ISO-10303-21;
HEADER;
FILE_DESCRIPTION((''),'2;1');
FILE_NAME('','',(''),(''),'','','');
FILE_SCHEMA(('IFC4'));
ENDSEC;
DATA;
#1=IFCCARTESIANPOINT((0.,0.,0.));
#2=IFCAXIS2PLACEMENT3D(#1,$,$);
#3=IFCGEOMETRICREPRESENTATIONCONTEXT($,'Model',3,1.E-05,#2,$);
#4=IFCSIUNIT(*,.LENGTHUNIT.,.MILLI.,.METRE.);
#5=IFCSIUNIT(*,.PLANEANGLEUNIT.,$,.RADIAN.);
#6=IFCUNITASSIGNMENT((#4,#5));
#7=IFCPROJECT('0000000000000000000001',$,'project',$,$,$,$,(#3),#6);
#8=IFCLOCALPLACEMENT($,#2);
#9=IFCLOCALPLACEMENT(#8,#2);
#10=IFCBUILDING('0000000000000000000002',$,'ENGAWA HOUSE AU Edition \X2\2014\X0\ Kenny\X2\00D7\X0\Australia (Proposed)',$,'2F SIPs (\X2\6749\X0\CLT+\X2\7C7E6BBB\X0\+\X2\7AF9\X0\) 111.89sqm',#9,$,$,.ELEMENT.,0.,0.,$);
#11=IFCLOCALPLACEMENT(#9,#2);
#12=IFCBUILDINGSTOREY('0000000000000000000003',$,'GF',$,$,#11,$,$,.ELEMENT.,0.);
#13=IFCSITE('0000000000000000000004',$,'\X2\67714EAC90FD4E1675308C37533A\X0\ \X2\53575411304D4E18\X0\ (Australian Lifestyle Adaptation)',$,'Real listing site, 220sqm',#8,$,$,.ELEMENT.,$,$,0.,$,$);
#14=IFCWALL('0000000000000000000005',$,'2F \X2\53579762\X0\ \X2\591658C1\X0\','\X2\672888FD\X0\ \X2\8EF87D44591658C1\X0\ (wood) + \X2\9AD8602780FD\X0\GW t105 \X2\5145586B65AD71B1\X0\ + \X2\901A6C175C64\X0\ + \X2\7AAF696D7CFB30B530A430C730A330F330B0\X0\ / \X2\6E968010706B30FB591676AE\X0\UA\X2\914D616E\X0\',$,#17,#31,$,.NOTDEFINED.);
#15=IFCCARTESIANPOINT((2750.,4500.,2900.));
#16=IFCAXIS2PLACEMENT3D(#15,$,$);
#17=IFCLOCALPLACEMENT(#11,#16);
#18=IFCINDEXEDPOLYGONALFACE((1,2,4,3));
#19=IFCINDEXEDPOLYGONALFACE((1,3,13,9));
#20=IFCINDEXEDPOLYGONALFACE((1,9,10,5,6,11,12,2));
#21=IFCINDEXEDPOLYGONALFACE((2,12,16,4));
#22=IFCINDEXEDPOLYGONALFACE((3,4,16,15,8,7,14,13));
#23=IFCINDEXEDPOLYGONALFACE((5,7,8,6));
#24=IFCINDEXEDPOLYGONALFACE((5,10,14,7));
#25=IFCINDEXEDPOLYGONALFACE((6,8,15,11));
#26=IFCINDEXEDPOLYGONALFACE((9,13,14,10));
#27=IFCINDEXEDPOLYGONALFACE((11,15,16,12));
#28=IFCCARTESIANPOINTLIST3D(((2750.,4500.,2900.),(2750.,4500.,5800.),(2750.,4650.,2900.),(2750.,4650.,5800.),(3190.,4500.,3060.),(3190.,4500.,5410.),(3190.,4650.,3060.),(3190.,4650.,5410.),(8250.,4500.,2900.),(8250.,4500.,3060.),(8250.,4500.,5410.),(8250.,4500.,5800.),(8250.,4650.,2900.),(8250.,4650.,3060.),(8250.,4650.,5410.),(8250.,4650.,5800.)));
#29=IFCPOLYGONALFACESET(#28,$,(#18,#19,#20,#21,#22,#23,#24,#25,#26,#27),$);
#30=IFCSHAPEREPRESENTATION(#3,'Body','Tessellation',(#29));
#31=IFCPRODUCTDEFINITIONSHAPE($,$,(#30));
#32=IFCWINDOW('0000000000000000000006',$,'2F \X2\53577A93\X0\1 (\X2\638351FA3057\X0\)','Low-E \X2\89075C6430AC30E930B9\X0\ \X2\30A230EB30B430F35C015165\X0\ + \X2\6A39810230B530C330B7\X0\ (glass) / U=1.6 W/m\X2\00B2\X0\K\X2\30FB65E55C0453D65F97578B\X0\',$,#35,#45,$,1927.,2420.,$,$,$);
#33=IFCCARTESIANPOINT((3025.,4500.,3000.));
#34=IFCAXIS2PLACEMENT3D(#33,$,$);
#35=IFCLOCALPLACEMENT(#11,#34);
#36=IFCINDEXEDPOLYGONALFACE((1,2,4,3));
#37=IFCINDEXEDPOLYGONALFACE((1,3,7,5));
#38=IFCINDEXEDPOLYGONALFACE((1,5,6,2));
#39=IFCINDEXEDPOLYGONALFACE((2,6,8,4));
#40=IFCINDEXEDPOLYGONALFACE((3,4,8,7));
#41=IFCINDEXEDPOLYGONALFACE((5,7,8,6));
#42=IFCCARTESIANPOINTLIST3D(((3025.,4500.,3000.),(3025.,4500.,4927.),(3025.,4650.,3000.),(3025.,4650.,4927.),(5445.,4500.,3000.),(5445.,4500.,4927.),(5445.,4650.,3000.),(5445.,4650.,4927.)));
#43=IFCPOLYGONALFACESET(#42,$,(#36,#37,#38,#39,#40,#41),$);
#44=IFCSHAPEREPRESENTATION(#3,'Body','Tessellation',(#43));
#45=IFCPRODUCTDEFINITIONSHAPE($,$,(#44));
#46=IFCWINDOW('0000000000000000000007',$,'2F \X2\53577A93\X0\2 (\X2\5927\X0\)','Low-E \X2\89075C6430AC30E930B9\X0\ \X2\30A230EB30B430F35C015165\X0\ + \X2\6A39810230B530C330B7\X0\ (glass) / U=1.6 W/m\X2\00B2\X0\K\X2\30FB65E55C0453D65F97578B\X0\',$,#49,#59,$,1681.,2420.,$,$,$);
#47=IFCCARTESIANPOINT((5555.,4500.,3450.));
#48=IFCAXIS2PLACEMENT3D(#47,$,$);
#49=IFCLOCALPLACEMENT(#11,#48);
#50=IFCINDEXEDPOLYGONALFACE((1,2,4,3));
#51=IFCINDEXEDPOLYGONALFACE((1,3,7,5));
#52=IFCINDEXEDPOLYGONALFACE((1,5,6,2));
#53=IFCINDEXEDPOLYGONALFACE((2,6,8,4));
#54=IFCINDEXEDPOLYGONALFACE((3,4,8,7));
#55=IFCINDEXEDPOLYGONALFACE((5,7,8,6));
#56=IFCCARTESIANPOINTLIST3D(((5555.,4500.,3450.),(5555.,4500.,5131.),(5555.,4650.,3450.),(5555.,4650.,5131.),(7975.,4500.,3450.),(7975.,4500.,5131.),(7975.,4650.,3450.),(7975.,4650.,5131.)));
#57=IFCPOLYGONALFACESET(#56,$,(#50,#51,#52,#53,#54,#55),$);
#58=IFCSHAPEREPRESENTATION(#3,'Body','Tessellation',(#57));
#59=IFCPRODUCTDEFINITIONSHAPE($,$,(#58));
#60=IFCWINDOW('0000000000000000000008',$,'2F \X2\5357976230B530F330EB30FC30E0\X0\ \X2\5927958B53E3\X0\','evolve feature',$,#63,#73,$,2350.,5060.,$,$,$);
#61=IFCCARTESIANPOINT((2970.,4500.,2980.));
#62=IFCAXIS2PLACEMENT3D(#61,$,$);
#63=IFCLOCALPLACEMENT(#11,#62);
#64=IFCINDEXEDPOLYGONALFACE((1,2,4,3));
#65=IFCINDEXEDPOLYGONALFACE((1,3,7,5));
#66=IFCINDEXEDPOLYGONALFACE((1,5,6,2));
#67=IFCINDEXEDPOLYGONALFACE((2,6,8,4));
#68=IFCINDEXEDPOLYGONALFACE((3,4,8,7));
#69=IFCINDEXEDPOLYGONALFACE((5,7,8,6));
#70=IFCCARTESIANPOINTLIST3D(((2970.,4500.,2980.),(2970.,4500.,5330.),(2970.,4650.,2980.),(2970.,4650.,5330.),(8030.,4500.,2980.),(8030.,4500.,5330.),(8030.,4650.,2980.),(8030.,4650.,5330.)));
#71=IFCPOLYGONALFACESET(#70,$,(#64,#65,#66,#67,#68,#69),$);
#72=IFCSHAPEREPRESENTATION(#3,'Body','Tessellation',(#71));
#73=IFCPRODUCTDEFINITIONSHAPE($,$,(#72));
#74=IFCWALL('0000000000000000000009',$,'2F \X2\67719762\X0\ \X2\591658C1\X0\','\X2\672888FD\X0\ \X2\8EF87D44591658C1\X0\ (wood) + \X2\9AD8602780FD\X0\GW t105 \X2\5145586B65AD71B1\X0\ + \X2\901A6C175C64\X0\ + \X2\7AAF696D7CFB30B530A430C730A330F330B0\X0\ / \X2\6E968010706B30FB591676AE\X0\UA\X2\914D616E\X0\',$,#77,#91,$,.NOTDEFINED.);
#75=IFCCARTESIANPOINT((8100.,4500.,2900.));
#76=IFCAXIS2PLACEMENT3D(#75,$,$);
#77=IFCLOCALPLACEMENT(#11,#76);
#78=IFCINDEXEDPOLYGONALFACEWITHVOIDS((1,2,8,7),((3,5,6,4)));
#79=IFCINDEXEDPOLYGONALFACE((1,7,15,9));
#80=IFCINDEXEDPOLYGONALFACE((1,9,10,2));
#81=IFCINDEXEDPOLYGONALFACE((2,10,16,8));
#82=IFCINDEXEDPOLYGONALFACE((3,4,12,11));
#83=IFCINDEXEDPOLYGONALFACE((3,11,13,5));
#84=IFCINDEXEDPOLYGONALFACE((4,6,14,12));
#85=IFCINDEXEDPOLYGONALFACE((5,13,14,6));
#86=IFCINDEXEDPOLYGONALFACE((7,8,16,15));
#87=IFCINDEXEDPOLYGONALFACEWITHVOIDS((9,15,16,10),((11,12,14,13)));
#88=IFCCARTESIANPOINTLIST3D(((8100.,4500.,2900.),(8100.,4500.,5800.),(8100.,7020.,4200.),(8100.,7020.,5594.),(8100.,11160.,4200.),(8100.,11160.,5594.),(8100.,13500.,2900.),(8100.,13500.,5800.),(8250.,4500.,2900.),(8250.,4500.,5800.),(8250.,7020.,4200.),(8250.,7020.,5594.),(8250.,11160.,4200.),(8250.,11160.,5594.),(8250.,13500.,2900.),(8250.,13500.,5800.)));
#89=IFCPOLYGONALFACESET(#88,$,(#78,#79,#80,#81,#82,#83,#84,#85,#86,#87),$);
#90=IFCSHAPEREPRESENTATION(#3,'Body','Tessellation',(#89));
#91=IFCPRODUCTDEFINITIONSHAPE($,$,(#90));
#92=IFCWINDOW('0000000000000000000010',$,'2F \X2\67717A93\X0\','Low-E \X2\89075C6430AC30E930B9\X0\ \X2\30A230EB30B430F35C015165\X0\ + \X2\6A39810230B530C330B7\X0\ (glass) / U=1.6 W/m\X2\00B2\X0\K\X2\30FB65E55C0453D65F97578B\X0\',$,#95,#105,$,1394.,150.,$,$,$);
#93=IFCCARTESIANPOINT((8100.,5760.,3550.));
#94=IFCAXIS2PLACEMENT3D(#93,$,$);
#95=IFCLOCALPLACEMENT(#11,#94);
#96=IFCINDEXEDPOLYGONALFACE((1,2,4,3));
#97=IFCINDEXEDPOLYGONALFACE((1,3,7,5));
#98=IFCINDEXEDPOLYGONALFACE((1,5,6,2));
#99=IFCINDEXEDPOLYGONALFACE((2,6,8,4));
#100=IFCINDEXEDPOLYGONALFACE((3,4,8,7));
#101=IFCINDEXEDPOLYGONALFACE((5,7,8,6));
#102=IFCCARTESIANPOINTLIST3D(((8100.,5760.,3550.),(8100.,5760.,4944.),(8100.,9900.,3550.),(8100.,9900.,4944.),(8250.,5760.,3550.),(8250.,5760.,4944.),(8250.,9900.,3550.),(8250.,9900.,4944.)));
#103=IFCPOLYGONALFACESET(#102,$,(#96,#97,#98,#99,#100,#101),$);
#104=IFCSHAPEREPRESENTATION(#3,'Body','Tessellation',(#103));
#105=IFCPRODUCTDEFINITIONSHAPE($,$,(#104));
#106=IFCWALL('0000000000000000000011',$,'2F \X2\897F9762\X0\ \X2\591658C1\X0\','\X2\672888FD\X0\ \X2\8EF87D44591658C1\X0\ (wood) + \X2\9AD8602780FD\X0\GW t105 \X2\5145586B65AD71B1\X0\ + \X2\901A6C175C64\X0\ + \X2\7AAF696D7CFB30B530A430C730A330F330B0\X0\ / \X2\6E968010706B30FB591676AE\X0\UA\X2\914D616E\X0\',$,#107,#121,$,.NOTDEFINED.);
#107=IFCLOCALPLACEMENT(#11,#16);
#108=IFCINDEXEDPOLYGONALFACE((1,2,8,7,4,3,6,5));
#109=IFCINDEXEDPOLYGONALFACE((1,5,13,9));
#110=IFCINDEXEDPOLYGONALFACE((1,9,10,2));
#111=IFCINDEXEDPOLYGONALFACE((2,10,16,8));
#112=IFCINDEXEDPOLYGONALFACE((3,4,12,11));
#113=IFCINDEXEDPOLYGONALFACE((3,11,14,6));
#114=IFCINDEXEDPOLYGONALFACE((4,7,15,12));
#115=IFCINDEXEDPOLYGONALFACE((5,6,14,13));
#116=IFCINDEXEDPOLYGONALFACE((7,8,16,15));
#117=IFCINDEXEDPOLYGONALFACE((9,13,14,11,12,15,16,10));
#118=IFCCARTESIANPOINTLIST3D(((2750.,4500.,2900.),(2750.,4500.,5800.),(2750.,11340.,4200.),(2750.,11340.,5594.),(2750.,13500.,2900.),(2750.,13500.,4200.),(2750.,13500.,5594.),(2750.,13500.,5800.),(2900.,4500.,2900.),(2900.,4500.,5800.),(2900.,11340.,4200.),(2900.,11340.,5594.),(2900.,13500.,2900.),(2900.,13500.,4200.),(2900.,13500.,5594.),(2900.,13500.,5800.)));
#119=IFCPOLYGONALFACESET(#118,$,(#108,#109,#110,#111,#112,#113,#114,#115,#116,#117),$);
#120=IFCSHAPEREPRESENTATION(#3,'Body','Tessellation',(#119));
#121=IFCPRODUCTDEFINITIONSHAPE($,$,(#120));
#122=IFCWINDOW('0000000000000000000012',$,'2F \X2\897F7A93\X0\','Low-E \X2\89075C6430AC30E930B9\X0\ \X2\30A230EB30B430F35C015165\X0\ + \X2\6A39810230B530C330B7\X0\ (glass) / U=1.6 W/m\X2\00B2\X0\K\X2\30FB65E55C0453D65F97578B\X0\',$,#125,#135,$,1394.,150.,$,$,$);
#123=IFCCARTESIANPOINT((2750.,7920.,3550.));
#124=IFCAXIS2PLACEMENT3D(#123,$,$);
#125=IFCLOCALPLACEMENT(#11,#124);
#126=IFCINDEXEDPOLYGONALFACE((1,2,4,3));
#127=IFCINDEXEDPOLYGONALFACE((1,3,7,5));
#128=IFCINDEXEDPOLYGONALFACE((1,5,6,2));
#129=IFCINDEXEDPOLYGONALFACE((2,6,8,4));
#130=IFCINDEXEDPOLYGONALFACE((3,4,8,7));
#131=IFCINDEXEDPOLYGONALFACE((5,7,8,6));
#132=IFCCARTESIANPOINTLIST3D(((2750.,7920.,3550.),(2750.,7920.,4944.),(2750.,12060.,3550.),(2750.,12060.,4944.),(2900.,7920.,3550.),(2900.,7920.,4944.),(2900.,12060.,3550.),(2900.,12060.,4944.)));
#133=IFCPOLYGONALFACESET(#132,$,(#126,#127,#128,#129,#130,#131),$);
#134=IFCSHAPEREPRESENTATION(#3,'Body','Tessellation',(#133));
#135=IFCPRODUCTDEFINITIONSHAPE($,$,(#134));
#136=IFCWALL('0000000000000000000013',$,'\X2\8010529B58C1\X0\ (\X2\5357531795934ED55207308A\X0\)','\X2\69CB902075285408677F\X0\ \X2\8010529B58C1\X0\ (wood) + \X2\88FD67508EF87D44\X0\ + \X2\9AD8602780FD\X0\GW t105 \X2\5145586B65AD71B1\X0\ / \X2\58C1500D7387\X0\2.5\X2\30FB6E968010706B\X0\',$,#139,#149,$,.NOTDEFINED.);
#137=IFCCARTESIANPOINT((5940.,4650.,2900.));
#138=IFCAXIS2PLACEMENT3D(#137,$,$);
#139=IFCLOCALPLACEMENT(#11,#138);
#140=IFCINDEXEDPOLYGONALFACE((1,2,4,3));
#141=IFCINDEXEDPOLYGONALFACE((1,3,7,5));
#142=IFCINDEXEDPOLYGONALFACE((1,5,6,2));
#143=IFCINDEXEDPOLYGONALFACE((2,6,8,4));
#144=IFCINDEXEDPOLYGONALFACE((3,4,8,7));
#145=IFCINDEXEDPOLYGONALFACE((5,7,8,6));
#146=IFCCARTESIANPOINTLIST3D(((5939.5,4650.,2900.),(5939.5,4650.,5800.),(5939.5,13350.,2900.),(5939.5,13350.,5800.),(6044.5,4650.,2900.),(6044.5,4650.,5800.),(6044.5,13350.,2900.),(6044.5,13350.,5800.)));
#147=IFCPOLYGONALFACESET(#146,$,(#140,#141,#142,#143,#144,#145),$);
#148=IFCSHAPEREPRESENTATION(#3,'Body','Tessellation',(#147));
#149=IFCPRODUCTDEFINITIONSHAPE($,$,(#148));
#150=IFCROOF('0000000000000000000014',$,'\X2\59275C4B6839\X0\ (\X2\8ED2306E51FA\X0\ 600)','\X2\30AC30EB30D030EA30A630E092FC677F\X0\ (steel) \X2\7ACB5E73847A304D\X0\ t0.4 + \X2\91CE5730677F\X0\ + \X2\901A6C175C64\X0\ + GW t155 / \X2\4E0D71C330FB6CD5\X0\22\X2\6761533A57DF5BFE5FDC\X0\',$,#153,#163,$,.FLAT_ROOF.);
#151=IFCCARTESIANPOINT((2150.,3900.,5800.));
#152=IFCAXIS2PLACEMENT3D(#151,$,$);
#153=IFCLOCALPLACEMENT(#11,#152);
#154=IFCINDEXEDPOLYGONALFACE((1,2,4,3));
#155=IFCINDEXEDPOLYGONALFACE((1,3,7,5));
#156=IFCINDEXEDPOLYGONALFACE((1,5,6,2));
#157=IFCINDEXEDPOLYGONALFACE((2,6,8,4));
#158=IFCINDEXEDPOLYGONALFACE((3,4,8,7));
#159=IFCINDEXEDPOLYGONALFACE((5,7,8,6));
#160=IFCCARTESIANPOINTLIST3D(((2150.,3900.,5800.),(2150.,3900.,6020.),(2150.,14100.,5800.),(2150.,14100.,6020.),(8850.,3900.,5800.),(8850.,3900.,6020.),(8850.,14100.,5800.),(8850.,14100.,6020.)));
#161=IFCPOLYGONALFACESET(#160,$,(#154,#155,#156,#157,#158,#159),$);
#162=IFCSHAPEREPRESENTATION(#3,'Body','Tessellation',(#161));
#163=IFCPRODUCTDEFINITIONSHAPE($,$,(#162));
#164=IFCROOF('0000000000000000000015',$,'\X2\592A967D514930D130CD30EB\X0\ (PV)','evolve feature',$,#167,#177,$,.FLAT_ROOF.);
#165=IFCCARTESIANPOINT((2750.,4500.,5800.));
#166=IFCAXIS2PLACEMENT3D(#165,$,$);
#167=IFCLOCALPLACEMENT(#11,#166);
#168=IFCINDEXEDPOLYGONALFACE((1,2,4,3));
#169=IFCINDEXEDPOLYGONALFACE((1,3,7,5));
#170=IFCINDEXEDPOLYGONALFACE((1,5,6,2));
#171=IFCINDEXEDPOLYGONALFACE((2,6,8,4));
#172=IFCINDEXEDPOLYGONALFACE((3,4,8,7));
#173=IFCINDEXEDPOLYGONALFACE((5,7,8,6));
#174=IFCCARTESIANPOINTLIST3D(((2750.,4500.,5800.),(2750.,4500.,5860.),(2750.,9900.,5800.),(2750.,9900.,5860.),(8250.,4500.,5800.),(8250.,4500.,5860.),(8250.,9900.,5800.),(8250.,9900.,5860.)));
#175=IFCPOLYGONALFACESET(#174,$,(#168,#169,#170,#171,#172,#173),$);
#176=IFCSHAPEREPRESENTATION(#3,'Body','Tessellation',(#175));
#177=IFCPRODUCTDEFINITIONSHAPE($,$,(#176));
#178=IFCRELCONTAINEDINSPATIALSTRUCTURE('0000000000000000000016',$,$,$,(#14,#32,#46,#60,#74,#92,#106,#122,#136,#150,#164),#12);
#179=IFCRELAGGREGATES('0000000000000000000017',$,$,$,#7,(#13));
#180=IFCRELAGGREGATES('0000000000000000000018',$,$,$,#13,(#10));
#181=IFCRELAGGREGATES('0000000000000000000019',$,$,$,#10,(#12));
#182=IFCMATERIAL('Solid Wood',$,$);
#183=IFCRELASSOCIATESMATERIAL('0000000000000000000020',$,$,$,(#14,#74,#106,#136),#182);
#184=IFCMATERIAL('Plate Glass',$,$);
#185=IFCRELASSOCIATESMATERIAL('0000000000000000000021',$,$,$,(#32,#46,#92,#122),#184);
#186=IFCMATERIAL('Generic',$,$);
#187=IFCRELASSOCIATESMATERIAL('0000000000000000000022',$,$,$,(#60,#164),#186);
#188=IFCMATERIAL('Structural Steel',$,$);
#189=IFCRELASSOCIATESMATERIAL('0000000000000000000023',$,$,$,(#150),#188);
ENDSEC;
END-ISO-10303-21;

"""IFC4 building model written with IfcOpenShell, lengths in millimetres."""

from ifc_helpers import new_model, si_unit, frame, frame_2d, origin, place, context, project, spatial, rectangle, extrude, material, element, fill, save


model = new_model("IFC4")

# Units and contexts
model_context = context("Model", 3, precision=1e-05, world=origin())
ifc_project = project(units=[si_unit("LENGTHUNIT", "METRE", prefix="MILLI"), si_unit("PLANEANGLEUNIT", "RADIAN")], contexts=[model_context])

# Site, building, storey
site_placement = place(None, origin())
site = spatial("IfcSite", under=ifc_project, at=site_placement, Name="東京都世田谷区 南向き丘 (Australian Lifestyle Adaptation)", ObjectType="Real listing site, 220sqm", CompositionType="ELEMENT", RefElevation=0.0)
building_placement = place(site_placement, origin())
building = spatial("IfcBuilding", under=site, at=building_placement, Name="ENGAWA HOUSE AU Edition — Kenny×Australia (Proposed)", ObjectType="2F SIPs (杉CLT+籾殻+竹) 111.89sqm", CompositionType="ELEMENT", ElevationOfRefHeight=0.0, ElevationOfTerrain=0.0)
storey_placement = place(building_placement, origin())
storey = spatial("IfcBuildingStorey", under=building, at=storey_placement, Name="GF", CompositionType="ELEMENT", Elevation=0.0)

# Shared definitions
ifc_material_1 = material(Name="Solid Wood")

# Wall, openings, windows
wall_1_placement = place(storey_placement, frame((2750.0, 4500.0, 2900.0)))
wall_1 = element("IfcWall", 1, at=wall_1_placement, inside=storey, material=ifc_material_1, Name="2F 南面 外壁", Description="木製 軸組外壁 (wood) + 高性能GW t105 充填断熱 + 通気層 + 窯業系サイディング / 準耐火・外皮UA配慮", PredefinedType="NOTDEFINED", context=model_context, shape_type="SweptSolid", body=[
    extrude(rectangle(XDim=5500.0, YDim=150.0, at=frame_2d((2750.0, 75.0))), frame((2750.0, 4500.0, 2900.0)), (0.0, 0.0, 1.0), 2900.0),
])
opening_1_placement = place(storey_placement, frame((3025.0, 4500.0, 3000.0)))
opening_1 = element("IfcOpeningElement", 2, at=opening_1_placement, cuts=wall_1, PredefinedType="NOTDEFINED", context=model_context, shape_type="SweptSolid", body=[
    extrude(rectangle(XDim=2420.0, YDim=150.0, at=frame_2d((1210.0, 75.0))), frame((3025.0, 4500.0, 3000.0)), (0.0, 0.0, 1.0), 1927.0),
])
opening_2_placement = place(storey_placement, frame((5555.0, 4500.0, 3450.0)))
opening_2 = element("IfcOpeningElement", 3, at=opening_2_placement, cuts=wall_1, PredefinedType="NOTDEFINED", context=model_context, shape_type="SweptSolid", body=[
    extrude(rectangle(XDim=2420.0, YDim=150.0, at=frame_2d((1210.0, 75.0))), frame((5555.0, 4500.0, 3450.0)), (0.0, 0.0, 1.0), 1681.0),
])
opening_3_placement = place(storey_placement, frame((2970.0, 4500.0, 2980.0)))
opening_3 = element("IfcOpeningElement", 4, at=opening_3_placement, cuts=wall_1, PredefinedType="NOTDEFINED", context=model_context, shape_type="SweptSolid", body=[
    extrude(rectangle(XDim=5060.0, YDim=150.0, at=frame_2d((2530.0, 75.0))), frame((2970.0, 4500.0, 2980.0)), (0.0, 0.0, 1.0), 2350.0),
])
ifc_material_2 = material(Name="Plate Glass")
window_1_placement = place(storey_placement, frame((3025.0, 4500.0, 3000.0)))
window_1 = element("IfcWindow", 5, at=window_1_placement, inside=storey, material=ifc_material_2, Name="2F 南窓1 (掃出し)", Description="Low-E 複層ガラス アルゴン封入 + 樹脂サッシ (glass) / U=1.6 W/m²K・日射取得型", OverallHeight=1927.0, OverallWidth=2420.0, context=model_context, shape_type="SweptSolid", body=[
    extrude(rectangle(XDim=2420.0, YDim=150.0, at=frame_2d((1210.0, 75.0))), frame((3025.0, 4500.0, 3000.0)), (0.0, 0.0, 1.0), 1927.0),
])
fill(opening_1, window_1)
window_2_placement = place(storey_placement, frame((5555.0, 4500.0, 3450.0)))
window_2 = element("IfcWindow", 6, at=window_2_placement, inside=storey, material=ifc_material_2, Name="2F 南窓2 (大)", Description="Low-E 複層ガラス アルゴン封入 + 樹脂サッシ (glass) / U=1.6 W/m²K・日射取得型", OverallHeight=1681.0, OverallWidth=2420.0, context=model_context, shape_type="SweptSolid", body=[
    extrude(rectangle(XDim=2420.0, YDim=150.0, at=frame_2d((1210.0, 75.0))), frame((5555.0, 4500.0, 3450.0)), (0.0, 0.0, 1.0), 1681.0),
])
fill(opening_2, window_2)
ifc_material_3 = material(Name="Generic")
window_3_placement = place(storey_placement, frame((2970.0, 4500.0, 2980.0)))
window_3 = element("IfcWindow", 7, at=window_3_placement, inside=storey, material=ifc_material_3, Name="2F 南面サンルーム 大開口", Description="evolve feature", OverallHeight=2350.0, OverallWidth=5060.0, context=model_context, shape_type="SweptSolid", body=[
    extrude(rectangle(XDim=5060.0, YDim=150.0, at=frame_2d((2530.0, 75.0))), frame((2970.0, 4500.0, 2980.0)), (0.0, 0.0, 1.0), 2350.0),
])
fill(opening_3, window_3)

# Walls, openings, windows
wall_2_placement = place(storey_placement, frame((8100.0, 4500.0, 2900.0)))
wall_2 = element("IfcWall", 8, at=wall_2_placement, inside=storey, material=ifc_material_1, Name="2F 東面 外壁", Description="木製 軸組外壁 (wood) + 高性能GW t105 充填断熱 + 通気層 + 窯業系サイディング / 準耐火・外皮UA配慮", PredefinedType="NOTDEFINED", context=model_context, shape_type="SweptSolid", body=[
    extrude(rectangle(XDim=150.0, YDim=9000.0, at=frame_2d((75.0, 4500.0))), frame((8100.0, 4500.0, 2900.0)), (0.0, 0.0, 1.0), 2900.0),
])
opening_4_placement = place(storey_placement, frame((8100.0, 5760.0, 3550.0)))
opening_4 = element("IfcOpeningElement", 9, at=opening_4_placement, cuts=wall_2, PredefinedType="NOTDEFINED", context=model_context, shape_type="SweptSolid", body=[
    extrude(rectangle(XDim=150.0, YDim=4140.0, at=frame_2d((75.0, 2070.0))), frame((8100.0, 5760.0, 3550.0)), (0.0, 0.0, 1.0), 1394.0),
])
window_4_placement = place(storey_placement, frame((8100.0, 5760.0, 3550.0)))
window_4 = element("IfcWindow", 10, at=window_4_placement, inside=storey, material=ifc_material_2, Name="2F 東窓", Description="Low-E 複層ガラス アルゴン封入 + 樹脂サッシ (glass) / U=1.6 W/m²K・日射取得型", OverallHeight=1394.0, OverallWidth=150.0, context=model_context, shape_type="SweptSolid", body=[
    extrude(rectangle(XDim=150.0, YDim=4140.0, at=frame_2d((75.0, 2070.0))), frame((8100.0, 5760.0, 3550.0)), (0.0, 0.0, 1.0), 1394.0),
])
fill(opening_4, window_4)
wall_3_placement = place(storey_placement, frame((2750.0, 4500.0, 2900.0)))
wall_3 = element("IfcWall", 11, at=wall_3_placement, inside=storey, material=ifc_material_1, Name="2F 西面 外壁", Description="木製 軸組外壁 (wood) + 高性能GW t105 充填断熱 + 通気層 + 窯業系サイディング / 準耐火・外皮UA配慮", PredefinedType="NOTDEFINED", context=model_context, shape_type="SweptSolid", body=[
    extrude(rectangle(XDim=150.0, YDim=9000.0, at=frame_2d((75.0, 4500.0))), frame((2750.0, 4500.0, 2900.0)), (0.0, 0.0, 1.0), 2900.0),
])
opening_5_placement = place(storey_placement, frame((2750.0, 7920.0, 3550.0)))
opening_5 = element("IfcOpeningElement", 12, at=opening_5_placement, cuts=wall_3, PredefinedType="NOTDEFINED", context=model_context, shape_type="SweptSolid", body=[
    extrude(rectangle(XDim=150.0, YDim=4140.0, at=frame_2d((75.0, 2070.0))), frame((2750.0, 7920.0, 3550.0)), (0.0, 0.0, 1.0), 1394.0),
])
window_5_placement = place(storey_placement, frame((2750.0, 7920.0, 3550.0)))
window_5 = element("IfcWindow", 13, at=window_5_placement, inside=storey, material=ifc_material_2, Name="2F 西窓", Description="Low-E 複層ガラス アルゴン封入 + 樹脂サッシ (glass) / U=1.6 W/m²K・日射取得型", OverallHeight=1394.0, OverallWidth=150.0, context=model_context, shape_type="SweptSolid", body=[
    extrude(rectangle(XDim=150.0, YDim=4140.0, at=frame_2d((75.0, 2070.0))), frame((2750.0, 7920.0, 3550.0)), (0.0, 0.0, 1.0), 1394.0),
])
fill(opening_5, window_5)

# Wall
wall_4_placement = place(storey_placement, frame((5940.0, 4650.0, 2900.0)))
element("IfcWall", 14, at=wall_4_placement, inside=storey, material=ifc_material_1, Name="耐力壁 (南北間仕切り)", Description="構造用合板 耐力壁 (wood) + 製材軸組 + 高性能GW t105 充填断熱 / 壁倍率2.5・準耐火", PredefinedType="NOTDEFINED", context=model_context, shape_type="SweptSolid", body=[
    extrude(rectangle(XDim=105.0, YDim=8700.0, at=frame_2d((52.0, 4350.0))), frame((5940.0, 4650.0, 2900.0)), (0.0, 0.0, 1.0), 2900.0),
])

# Roofs
ifc_material_4 = material(Name="Structural Steel")
roof_1_placement = place(storey_placement, frame((2150.0, 3900.0, 5800.0)))
element("IfcRoof", 15, at=roof_1_placement, inside=storey, material=ifc_material_4, Name="大屋根 (軒の出 600)", Description="ガルバリウム鋼板 (steel) 立平葺き t0.4 + 野地板 + 通気層 + GW t155 / 不燃・法22条区域対応", PredefinedType="FLAT_ROOF", context=model_context, shape_type="SweptSolid", body=[
    extrude(rectangle(XDim=6700.0, YDim=10200.0, at=frame_2d((3350.0, 5100.0))), frame((2150.0, 3900.0, 5800.0)), (0.0, 0.0, 1.0), 220.0),
])
roof_2_placement = place(storey_placement, frame((2750.0, 4500.0, 5800.0)))
element("IfcRoof", 16, at=roof_2_placement, inside=storey, material=ifc_material_3, Name="太陽光パネル (PV)", Description="evolve feature", PredefinedType="FLAT_ROOF", context=model_context, shape_type="SweptSolid", body=[
    extrude(rectangle(XDim=5500.0, YDim=5400.0, at=frame_2d((2750.0, 2700.0))), frame((2750.0, 4500.0, 5800.0)), (0.0, 0.0, 1.0), 60.0),
])

save(model, "model.ifc")
